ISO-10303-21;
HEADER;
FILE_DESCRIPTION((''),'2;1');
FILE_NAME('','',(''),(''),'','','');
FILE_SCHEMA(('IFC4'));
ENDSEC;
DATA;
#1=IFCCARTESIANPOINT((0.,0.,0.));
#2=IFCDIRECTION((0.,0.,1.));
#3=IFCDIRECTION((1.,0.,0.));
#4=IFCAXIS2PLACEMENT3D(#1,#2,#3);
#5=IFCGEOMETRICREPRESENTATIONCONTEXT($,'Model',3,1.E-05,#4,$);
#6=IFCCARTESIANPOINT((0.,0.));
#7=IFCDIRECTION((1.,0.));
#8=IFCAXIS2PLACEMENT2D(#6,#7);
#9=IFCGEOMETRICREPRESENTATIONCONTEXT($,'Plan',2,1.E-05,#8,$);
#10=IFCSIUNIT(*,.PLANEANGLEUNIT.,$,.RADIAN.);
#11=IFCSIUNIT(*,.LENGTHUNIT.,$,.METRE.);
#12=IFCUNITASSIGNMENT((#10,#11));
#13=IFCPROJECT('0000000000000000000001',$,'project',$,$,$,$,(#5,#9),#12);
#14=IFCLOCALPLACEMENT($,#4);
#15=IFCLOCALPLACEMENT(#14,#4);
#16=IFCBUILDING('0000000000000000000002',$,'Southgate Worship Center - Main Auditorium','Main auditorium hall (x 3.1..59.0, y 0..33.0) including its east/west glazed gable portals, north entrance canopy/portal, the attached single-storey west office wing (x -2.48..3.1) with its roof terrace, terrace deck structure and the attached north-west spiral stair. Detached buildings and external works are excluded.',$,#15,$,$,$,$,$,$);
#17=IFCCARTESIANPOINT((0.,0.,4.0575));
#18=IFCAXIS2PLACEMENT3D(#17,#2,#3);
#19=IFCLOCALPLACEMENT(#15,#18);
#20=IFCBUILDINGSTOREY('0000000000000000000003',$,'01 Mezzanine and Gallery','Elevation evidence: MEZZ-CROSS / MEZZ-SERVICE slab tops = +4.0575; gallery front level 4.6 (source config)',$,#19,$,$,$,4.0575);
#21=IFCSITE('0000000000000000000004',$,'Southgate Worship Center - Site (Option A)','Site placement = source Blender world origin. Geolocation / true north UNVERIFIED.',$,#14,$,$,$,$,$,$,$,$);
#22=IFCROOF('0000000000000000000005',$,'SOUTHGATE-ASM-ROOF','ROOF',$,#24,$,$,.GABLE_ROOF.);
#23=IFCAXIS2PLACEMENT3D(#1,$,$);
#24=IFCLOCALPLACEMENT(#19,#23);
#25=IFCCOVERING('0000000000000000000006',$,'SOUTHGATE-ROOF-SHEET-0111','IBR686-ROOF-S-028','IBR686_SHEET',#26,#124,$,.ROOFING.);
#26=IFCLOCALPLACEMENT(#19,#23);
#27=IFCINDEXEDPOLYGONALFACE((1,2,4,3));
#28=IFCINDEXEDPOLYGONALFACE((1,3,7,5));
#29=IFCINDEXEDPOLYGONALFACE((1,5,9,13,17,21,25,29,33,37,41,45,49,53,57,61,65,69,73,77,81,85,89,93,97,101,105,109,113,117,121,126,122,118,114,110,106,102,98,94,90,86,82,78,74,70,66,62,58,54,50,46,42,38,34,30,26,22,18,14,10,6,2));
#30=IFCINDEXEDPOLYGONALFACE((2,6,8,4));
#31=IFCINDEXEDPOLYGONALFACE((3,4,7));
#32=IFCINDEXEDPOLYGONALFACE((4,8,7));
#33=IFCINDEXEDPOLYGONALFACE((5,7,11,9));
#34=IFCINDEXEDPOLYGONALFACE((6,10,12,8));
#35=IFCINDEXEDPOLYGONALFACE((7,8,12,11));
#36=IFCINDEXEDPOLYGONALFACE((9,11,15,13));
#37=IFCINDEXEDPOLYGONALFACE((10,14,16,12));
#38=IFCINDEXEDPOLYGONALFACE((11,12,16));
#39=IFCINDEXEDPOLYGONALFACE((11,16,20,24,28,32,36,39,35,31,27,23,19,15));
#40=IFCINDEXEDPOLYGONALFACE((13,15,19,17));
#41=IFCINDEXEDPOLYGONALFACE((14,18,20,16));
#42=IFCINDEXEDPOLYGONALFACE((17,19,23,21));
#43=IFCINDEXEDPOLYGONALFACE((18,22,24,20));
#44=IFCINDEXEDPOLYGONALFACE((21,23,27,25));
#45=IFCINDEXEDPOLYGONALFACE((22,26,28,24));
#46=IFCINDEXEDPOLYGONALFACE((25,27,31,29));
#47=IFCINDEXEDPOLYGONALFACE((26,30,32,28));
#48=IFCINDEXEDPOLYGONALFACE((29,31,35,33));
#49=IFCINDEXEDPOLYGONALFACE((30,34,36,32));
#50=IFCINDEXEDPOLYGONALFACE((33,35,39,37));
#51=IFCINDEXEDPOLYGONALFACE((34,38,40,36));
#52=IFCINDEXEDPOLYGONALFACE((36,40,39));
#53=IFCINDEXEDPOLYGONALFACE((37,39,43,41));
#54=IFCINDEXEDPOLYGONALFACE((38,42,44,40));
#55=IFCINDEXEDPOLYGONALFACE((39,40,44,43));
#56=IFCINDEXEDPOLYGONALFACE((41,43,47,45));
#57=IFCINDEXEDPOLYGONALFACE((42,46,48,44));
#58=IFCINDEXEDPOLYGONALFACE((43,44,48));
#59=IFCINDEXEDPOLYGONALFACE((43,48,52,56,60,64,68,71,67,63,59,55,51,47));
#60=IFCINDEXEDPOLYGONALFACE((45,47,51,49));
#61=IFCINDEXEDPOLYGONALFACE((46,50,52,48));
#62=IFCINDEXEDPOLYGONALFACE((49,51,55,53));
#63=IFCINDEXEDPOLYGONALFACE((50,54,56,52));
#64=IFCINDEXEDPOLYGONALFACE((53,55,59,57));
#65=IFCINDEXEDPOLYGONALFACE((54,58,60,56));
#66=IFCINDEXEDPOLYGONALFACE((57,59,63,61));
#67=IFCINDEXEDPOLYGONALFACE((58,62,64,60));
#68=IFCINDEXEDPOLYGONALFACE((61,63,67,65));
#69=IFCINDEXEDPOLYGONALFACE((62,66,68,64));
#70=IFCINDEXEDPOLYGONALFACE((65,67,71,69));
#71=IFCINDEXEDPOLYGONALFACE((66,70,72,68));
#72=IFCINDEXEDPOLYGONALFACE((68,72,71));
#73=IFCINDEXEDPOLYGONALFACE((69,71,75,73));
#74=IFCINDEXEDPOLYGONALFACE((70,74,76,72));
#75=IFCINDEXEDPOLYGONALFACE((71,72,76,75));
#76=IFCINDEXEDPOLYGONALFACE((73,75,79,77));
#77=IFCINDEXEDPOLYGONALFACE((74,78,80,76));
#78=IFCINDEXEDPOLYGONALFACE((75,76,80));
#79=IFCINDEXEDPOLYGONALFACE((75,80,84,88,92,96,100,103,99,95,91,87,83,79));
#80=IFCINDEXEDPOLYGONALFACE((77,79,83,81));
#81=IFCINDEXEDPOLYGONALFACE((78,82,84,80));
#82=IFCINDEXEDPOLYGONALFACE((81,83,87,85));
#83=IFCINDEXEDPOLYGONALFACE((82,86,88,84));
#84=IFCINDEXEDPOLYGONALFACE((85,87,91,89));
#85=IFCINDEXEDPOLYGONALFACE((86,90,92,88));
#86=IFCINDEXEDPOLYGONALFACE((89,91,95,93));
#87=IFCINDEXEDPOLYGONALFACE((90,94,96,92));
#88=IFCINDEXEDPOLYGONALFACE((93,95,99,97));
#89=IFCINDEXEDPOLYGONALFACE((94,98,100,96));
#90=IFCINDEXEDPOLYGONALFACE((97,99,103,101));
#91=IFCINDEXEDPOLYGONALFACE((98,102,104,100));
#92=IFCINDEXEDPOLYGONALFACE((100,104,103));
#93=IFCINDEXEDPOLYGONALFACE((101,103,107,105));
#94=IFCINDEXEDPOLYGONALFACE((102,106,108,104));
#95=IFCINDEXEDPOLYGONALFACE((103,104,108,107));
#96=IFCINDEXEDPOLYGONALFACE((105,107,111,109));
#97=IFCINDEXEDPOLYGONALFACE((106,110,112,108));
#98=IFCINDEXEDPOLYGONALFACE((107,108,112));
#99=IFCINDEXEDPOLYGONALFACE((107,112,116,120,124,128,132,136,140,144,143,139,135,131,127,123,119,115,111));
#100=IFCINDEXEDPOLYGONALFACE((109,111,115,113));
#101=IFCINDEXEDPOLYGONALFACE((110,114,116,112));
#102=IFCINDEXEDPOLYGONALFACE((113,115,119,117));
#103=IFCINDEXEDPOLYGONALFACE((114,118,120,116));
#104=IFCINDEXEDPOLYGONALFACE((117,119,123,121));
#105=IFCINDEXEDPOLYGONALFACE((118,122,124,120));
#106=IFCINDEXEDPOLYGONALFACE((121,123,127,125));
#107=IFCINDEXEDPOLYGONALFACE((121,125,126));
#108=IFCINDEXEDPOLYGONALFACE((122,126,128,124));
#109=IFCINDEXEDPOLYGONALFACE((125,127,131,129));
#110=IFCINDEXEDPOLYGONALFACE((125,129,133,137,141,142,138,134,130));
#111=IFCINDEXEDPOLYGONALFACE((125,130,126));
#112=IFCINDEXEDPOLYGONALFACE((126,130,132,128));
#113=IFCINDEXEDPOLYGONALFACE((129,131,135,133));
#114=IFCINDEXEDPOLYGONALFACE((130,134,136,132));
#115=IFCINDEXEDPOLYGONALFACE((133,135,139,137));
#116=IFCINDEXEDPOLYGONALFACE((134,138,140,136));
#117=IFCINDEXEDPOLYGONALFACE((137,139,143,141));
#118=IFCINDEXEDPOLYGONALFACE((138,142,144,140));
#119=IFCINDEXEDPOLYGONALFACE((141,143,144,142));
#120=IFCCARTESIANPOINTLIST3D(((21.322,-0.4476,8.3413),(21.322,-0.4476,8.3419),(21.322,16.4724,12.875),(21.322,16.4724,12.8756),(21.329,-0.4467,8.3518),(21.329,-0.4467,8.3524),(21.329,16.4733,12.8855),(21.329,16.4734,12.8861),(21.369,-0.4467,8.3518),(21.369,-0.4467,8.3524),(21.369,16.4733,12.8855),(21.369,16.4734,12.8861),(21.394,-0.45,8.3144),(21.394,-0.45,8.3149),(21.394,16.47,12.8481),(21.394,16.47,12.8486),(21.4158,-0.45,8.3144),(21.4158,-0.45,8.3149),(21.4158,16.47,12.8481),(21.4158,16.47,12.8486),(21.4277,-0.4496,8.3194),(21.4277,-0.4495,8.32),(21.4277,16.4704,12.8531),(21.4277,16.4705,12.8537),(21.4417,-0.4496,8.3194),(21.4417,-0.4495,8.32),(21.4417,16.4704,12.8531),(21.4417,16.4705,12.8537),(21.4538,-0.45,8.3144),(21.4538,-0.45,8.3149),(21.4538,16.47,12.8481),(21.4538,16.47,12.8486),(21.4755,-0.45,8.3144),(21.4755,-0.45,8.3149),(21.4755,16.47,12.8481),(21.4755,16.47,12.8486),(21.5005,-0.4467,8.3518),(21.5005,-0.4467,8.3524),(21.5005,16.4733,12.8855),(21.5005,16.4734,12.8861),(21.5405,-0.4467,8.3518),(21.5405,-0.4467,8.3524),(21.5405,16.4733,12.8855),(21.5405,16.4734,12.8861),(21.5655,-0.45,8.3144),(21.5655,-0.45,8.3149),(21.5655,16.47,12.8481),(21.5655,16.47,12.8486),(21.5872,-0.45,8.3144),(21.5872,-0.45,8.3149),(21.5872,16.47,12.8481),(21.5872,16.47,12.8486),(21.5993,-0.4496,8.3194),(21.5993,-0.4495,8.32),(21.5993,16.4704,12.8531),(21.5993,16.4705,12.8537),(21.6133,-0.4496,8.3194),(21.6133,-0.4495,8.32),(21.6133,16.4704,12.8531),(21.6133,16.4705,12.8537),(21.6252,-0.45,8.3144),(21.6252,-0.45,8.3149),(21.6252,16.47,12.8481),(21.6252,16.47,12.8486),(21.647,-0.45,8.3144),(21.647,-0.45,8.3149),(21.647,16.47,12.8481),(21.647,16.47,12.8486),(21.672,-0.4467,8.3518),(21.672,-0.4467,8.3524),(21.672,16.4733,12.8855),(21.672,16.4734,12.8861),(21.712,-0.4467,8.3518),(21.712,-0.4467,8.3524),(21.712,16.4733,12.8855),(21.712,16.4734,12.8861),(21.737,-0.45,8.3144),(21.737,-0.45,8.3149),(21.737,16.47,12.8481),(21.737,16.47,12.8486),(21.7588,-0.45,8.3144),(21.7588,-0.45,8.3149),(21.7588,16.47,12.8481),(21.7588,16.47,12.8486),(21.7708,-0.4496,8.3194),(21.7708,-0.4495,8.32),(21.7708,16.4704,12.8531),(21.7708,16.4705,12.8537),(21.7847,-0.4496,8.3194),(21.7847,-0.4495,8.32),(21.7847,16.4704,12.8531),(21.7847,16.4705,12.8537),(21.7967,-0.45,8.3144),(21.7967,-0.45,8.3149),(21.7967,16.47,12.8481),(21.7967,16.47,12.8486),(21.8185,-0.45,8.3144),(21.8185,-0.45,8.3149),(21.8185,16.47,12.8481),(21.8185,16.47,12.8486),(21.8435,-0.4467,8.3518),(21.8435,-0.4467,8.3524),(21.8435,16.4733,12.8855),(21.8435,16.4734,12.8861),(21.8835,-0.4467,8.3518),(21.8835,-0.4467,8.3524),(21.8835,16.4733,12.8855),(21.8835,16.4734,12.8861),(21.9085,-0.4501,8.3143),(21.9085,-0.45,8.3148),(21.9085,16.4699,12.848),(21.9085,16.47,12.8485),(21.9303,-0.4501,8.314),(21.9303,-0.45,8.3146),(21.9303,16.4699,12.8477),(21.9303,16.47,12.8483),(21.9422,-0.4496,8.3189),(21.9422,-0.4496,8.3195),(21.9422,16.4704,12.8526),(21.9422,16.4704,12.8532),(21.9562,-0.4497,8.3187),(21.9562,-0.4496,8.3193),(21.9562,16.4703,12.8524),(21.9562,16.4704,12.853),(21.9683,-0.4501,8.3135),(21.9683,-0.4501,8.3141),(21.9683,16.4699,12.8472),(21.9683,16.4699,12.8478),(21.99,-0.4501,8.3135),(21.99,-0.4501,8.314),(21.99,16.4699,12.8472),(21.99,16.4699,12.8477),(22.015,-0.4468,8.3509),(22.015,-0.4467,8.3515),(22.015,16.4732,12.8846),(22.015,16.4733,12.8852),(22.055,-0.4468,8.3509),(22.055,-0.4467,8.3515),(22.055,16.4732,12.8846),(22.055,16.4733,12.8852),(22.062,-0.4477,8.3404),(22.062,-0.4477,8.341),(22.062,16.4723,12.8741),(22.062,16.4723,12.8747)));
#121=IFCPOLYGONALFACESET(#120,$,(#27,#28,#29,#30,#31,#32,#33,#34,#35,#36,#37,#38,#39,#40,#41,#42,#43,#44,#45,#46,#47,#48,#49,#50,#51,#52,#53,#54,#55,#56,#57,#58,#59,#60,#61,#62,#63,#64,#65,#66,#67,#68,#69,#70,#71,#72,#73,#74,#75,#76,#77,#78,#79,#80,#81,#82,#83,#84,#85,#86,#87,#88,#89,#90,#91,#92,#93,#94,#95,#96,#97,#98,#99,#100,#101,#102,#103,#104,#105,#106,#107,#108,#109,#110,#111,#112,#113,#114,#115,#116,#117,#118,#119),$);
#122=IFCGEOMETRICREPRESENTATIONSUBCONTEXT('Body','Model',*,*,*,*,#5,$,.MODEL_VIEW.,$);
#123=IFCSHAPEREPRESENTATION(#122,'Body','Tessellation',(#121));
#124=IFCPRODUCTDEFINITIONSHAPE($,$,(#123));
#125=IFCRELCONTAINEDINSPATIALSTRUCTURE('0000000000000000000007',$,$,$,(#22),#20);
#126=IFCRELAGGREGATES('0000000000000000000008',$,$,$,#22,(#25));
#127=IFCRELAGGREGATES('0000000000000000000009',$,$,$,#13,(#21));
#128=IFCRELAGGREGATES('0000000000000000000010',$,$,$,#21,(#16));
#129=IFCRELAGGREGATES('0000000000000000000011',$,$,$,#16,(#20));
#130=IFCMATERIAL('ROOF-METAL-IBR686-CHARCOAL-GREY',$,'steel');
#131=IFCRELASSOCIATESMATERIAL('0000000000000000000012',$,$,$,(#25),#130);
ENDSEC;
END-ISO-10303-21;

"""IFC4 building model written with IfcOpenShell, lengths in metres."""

from ifc_helpers import new_model, si_unit, frame, origin_with_axes, origin_2d_with_axis, place, context, subcontext, project, spatial, indexed_curve, outline, extrude, clip, halfspace, material, element, aggregate, save


model = new_model("IFC4")

# Units and contexts
model_context = context("Model", 3, precision=1e-05, world=origin_with_axes())
plan_context = context("Plan", 2, precision=1e-05, world=origin_2d_with_axis())
body_context = subcontext(model_context, "Body", "Model", "MODEL_VIEW")
ifc_project = project(units=[si_unit("PLANEANGLEUNIT", "RADIAN"), si_unit("LENGTHUNIT", "METRE")], contexts=[model_context, plan_context])

# Site, building, storey
site_placement = place(None, origin_with_axes())
site = spatial("IfcSite", under=ifc_project, at=site_placement, Name="Southgate Worship Center - Site (Option A)", Description="Site placement = source Blender world origin. Geolocation / true north UNVERIFIED.")
building_placement = place(site_placement, origin_with_axes())
building = spatial("IfcBuilding", under=site, at=building_placement, Name="Southgate Worship Center - Main Auditorium", Description="Main auditorium hall (x 3.1..59.0, y 0..33.0) including its east/west glazed gable portals, north entrance canopy/portal, the attached single-storey west office wing (x -2.48..3.1) with its roof terrace, terrace deck structure and the attached north-west spiral stair. Detached buildings and external works are excluded.")
storey_placement = place(building_placement, frame((0.0, 0.0, 4.0575), z_axis=(0.0, 0.0, 1.0), x_axis=(1.0, 0.0, 0.0)))
storey = spatial("IfcBuildingStorey", under=building, at=storey_placement, Name="01 Mezzanine and Gallery", Description="Elevation evidence: MEZZ-CROSS / MEZZ-SERVICE slab tops = +4.0575; gallery front level 4.6 (source config)", Elevation=4.0575)

# Roof, covering
roof_placement = place(storey_placement, origin_with_axes())
roof = element("IfcRoof", 1, at=roof_placement, inside=storey, Name="SOUTHGATE-ASM-ROOF", Description="ROOF", PredefinedType="GABLE_ROOF")
ifc_material_1 = material(Name="ROOF-METAL-IBR686-CHARCOAL-GREY", Category="steel")
covering_1_placement = place(roof_placement, frame((21.322, -0.4501, 8.3135), z_axis=(0.0, 0.0, 1.0), x_axis=(1.0, 0.0, 0.0)))
covering_1 = element("IfcCovering", 2, at=covering_1_placement, material=ifc_material_1, Name="SOUTHGATE-ROOF-SHEET-0111", Description="IBR686-ROOF-S-028", ObjectType="IBR686_SHEET", PredefinedType="ROOFING", context=body_context, shape_type="Clipping", body=[
    clip(clip(extrude(outline(indexed_curve([(0.0, 0.0), (0.025, 0.0353), (0.065, 0.0353), (0.072, 0.0254), (0.072, 0.0259), (0.065, 0.0358), (0.025, 0.0358), (0.0, 0.0005), (-0.0218, 0.0005), (-0.0338, 0.0053), (-0.0478, 0.0053), (-0.0598, 0.0005), (-0.0815, 0.0005), (-0.1065, 0.0358), (-0.1465, 0.0358), (-0.1715, 0.0005), (-0.1933, 0.0005), (-0.2053, 0.0053), (-0.2193, 0.0053), (-0.2313, 0.0005), (-0.253, 0.0005), (-0.278, 0.0358), (-0.318, 0.0358), (-0.343, 0.0005), (-0.3648, 0.0005), (-0.3768, 0.0053), (-0.3908, 0.0053), (-0.4028, 0.0005), (-0.4245, 0.0005), (-0.4495, 0.0358), (-0.4895, 0.0358), (-0.5145, 0.0004), (-0.5363, 0.0002), (-0.5483, 0.0048), (-0.5623, 0.0046), (-0.5743, -0.0003), (-0.596, -0.0004), (-0.621, 0.0349), (-0.661, 0.0349), (-0.668, 0.0251), (-0.668, 0.0246), (-0.661, 0.0344), (-0.621, 0.0344), (-0.596, -0.0009), (-0.5743, -0.0008), (-0.5623, 0.0041), (-0.5483, 0.0043), (-0.5363, -0.0003), (-0.5145, -0.0001), (-0.4895, 0.0353), (-0.4495, 0.0353), (-0.4245, 0.0), (-0.4028, 0.0), (-0.3908, 0.0048), (-0.3768, 0.0048), (-0.3648, 0.0), (-0.343, 0.0), (-0.318, 0.0353), (-0.278, 0.0353), (-0.253, 0.0), (-0.2313, 0.0), (-0.2193, 0.0048), (-0.2053, 0.0048), (-0.1933, 0.0), (-0.1715, 0.0), (-0.1465, 0.0353), (-0.1065, 0.0353), (-0.0815, 0.0), (-0.0598, 0.0), (-0.0478, 0.0048), (-0.0338, 0.0048), (-0.0218, 0.0), (0.0, 0.0)], self_intersect=False)), frame((0.072, -0.0003, 0.0008), z_axis=(0.0, 0.965926, 0.258819), x_axis=(-1.0, 0.0, 0.0)), (0.0, 0.0, 1.0), 17.5303), halfspace(frame((0.37, 0.0012, 0.014), z_axis=(0.0, -0.996022, 0.089113), x_axis=(1.0, 0.0, 0.0)), False)), halfspace(frame((0.37, 16.9212, 4.5477), z_axis=(0.0, 0.996021, -0.089119), x_axis=(-1.0, 0.0, 0.0)), False)),
])
aggregate(roof, [covering_1])

save(model, "model.ifc")
